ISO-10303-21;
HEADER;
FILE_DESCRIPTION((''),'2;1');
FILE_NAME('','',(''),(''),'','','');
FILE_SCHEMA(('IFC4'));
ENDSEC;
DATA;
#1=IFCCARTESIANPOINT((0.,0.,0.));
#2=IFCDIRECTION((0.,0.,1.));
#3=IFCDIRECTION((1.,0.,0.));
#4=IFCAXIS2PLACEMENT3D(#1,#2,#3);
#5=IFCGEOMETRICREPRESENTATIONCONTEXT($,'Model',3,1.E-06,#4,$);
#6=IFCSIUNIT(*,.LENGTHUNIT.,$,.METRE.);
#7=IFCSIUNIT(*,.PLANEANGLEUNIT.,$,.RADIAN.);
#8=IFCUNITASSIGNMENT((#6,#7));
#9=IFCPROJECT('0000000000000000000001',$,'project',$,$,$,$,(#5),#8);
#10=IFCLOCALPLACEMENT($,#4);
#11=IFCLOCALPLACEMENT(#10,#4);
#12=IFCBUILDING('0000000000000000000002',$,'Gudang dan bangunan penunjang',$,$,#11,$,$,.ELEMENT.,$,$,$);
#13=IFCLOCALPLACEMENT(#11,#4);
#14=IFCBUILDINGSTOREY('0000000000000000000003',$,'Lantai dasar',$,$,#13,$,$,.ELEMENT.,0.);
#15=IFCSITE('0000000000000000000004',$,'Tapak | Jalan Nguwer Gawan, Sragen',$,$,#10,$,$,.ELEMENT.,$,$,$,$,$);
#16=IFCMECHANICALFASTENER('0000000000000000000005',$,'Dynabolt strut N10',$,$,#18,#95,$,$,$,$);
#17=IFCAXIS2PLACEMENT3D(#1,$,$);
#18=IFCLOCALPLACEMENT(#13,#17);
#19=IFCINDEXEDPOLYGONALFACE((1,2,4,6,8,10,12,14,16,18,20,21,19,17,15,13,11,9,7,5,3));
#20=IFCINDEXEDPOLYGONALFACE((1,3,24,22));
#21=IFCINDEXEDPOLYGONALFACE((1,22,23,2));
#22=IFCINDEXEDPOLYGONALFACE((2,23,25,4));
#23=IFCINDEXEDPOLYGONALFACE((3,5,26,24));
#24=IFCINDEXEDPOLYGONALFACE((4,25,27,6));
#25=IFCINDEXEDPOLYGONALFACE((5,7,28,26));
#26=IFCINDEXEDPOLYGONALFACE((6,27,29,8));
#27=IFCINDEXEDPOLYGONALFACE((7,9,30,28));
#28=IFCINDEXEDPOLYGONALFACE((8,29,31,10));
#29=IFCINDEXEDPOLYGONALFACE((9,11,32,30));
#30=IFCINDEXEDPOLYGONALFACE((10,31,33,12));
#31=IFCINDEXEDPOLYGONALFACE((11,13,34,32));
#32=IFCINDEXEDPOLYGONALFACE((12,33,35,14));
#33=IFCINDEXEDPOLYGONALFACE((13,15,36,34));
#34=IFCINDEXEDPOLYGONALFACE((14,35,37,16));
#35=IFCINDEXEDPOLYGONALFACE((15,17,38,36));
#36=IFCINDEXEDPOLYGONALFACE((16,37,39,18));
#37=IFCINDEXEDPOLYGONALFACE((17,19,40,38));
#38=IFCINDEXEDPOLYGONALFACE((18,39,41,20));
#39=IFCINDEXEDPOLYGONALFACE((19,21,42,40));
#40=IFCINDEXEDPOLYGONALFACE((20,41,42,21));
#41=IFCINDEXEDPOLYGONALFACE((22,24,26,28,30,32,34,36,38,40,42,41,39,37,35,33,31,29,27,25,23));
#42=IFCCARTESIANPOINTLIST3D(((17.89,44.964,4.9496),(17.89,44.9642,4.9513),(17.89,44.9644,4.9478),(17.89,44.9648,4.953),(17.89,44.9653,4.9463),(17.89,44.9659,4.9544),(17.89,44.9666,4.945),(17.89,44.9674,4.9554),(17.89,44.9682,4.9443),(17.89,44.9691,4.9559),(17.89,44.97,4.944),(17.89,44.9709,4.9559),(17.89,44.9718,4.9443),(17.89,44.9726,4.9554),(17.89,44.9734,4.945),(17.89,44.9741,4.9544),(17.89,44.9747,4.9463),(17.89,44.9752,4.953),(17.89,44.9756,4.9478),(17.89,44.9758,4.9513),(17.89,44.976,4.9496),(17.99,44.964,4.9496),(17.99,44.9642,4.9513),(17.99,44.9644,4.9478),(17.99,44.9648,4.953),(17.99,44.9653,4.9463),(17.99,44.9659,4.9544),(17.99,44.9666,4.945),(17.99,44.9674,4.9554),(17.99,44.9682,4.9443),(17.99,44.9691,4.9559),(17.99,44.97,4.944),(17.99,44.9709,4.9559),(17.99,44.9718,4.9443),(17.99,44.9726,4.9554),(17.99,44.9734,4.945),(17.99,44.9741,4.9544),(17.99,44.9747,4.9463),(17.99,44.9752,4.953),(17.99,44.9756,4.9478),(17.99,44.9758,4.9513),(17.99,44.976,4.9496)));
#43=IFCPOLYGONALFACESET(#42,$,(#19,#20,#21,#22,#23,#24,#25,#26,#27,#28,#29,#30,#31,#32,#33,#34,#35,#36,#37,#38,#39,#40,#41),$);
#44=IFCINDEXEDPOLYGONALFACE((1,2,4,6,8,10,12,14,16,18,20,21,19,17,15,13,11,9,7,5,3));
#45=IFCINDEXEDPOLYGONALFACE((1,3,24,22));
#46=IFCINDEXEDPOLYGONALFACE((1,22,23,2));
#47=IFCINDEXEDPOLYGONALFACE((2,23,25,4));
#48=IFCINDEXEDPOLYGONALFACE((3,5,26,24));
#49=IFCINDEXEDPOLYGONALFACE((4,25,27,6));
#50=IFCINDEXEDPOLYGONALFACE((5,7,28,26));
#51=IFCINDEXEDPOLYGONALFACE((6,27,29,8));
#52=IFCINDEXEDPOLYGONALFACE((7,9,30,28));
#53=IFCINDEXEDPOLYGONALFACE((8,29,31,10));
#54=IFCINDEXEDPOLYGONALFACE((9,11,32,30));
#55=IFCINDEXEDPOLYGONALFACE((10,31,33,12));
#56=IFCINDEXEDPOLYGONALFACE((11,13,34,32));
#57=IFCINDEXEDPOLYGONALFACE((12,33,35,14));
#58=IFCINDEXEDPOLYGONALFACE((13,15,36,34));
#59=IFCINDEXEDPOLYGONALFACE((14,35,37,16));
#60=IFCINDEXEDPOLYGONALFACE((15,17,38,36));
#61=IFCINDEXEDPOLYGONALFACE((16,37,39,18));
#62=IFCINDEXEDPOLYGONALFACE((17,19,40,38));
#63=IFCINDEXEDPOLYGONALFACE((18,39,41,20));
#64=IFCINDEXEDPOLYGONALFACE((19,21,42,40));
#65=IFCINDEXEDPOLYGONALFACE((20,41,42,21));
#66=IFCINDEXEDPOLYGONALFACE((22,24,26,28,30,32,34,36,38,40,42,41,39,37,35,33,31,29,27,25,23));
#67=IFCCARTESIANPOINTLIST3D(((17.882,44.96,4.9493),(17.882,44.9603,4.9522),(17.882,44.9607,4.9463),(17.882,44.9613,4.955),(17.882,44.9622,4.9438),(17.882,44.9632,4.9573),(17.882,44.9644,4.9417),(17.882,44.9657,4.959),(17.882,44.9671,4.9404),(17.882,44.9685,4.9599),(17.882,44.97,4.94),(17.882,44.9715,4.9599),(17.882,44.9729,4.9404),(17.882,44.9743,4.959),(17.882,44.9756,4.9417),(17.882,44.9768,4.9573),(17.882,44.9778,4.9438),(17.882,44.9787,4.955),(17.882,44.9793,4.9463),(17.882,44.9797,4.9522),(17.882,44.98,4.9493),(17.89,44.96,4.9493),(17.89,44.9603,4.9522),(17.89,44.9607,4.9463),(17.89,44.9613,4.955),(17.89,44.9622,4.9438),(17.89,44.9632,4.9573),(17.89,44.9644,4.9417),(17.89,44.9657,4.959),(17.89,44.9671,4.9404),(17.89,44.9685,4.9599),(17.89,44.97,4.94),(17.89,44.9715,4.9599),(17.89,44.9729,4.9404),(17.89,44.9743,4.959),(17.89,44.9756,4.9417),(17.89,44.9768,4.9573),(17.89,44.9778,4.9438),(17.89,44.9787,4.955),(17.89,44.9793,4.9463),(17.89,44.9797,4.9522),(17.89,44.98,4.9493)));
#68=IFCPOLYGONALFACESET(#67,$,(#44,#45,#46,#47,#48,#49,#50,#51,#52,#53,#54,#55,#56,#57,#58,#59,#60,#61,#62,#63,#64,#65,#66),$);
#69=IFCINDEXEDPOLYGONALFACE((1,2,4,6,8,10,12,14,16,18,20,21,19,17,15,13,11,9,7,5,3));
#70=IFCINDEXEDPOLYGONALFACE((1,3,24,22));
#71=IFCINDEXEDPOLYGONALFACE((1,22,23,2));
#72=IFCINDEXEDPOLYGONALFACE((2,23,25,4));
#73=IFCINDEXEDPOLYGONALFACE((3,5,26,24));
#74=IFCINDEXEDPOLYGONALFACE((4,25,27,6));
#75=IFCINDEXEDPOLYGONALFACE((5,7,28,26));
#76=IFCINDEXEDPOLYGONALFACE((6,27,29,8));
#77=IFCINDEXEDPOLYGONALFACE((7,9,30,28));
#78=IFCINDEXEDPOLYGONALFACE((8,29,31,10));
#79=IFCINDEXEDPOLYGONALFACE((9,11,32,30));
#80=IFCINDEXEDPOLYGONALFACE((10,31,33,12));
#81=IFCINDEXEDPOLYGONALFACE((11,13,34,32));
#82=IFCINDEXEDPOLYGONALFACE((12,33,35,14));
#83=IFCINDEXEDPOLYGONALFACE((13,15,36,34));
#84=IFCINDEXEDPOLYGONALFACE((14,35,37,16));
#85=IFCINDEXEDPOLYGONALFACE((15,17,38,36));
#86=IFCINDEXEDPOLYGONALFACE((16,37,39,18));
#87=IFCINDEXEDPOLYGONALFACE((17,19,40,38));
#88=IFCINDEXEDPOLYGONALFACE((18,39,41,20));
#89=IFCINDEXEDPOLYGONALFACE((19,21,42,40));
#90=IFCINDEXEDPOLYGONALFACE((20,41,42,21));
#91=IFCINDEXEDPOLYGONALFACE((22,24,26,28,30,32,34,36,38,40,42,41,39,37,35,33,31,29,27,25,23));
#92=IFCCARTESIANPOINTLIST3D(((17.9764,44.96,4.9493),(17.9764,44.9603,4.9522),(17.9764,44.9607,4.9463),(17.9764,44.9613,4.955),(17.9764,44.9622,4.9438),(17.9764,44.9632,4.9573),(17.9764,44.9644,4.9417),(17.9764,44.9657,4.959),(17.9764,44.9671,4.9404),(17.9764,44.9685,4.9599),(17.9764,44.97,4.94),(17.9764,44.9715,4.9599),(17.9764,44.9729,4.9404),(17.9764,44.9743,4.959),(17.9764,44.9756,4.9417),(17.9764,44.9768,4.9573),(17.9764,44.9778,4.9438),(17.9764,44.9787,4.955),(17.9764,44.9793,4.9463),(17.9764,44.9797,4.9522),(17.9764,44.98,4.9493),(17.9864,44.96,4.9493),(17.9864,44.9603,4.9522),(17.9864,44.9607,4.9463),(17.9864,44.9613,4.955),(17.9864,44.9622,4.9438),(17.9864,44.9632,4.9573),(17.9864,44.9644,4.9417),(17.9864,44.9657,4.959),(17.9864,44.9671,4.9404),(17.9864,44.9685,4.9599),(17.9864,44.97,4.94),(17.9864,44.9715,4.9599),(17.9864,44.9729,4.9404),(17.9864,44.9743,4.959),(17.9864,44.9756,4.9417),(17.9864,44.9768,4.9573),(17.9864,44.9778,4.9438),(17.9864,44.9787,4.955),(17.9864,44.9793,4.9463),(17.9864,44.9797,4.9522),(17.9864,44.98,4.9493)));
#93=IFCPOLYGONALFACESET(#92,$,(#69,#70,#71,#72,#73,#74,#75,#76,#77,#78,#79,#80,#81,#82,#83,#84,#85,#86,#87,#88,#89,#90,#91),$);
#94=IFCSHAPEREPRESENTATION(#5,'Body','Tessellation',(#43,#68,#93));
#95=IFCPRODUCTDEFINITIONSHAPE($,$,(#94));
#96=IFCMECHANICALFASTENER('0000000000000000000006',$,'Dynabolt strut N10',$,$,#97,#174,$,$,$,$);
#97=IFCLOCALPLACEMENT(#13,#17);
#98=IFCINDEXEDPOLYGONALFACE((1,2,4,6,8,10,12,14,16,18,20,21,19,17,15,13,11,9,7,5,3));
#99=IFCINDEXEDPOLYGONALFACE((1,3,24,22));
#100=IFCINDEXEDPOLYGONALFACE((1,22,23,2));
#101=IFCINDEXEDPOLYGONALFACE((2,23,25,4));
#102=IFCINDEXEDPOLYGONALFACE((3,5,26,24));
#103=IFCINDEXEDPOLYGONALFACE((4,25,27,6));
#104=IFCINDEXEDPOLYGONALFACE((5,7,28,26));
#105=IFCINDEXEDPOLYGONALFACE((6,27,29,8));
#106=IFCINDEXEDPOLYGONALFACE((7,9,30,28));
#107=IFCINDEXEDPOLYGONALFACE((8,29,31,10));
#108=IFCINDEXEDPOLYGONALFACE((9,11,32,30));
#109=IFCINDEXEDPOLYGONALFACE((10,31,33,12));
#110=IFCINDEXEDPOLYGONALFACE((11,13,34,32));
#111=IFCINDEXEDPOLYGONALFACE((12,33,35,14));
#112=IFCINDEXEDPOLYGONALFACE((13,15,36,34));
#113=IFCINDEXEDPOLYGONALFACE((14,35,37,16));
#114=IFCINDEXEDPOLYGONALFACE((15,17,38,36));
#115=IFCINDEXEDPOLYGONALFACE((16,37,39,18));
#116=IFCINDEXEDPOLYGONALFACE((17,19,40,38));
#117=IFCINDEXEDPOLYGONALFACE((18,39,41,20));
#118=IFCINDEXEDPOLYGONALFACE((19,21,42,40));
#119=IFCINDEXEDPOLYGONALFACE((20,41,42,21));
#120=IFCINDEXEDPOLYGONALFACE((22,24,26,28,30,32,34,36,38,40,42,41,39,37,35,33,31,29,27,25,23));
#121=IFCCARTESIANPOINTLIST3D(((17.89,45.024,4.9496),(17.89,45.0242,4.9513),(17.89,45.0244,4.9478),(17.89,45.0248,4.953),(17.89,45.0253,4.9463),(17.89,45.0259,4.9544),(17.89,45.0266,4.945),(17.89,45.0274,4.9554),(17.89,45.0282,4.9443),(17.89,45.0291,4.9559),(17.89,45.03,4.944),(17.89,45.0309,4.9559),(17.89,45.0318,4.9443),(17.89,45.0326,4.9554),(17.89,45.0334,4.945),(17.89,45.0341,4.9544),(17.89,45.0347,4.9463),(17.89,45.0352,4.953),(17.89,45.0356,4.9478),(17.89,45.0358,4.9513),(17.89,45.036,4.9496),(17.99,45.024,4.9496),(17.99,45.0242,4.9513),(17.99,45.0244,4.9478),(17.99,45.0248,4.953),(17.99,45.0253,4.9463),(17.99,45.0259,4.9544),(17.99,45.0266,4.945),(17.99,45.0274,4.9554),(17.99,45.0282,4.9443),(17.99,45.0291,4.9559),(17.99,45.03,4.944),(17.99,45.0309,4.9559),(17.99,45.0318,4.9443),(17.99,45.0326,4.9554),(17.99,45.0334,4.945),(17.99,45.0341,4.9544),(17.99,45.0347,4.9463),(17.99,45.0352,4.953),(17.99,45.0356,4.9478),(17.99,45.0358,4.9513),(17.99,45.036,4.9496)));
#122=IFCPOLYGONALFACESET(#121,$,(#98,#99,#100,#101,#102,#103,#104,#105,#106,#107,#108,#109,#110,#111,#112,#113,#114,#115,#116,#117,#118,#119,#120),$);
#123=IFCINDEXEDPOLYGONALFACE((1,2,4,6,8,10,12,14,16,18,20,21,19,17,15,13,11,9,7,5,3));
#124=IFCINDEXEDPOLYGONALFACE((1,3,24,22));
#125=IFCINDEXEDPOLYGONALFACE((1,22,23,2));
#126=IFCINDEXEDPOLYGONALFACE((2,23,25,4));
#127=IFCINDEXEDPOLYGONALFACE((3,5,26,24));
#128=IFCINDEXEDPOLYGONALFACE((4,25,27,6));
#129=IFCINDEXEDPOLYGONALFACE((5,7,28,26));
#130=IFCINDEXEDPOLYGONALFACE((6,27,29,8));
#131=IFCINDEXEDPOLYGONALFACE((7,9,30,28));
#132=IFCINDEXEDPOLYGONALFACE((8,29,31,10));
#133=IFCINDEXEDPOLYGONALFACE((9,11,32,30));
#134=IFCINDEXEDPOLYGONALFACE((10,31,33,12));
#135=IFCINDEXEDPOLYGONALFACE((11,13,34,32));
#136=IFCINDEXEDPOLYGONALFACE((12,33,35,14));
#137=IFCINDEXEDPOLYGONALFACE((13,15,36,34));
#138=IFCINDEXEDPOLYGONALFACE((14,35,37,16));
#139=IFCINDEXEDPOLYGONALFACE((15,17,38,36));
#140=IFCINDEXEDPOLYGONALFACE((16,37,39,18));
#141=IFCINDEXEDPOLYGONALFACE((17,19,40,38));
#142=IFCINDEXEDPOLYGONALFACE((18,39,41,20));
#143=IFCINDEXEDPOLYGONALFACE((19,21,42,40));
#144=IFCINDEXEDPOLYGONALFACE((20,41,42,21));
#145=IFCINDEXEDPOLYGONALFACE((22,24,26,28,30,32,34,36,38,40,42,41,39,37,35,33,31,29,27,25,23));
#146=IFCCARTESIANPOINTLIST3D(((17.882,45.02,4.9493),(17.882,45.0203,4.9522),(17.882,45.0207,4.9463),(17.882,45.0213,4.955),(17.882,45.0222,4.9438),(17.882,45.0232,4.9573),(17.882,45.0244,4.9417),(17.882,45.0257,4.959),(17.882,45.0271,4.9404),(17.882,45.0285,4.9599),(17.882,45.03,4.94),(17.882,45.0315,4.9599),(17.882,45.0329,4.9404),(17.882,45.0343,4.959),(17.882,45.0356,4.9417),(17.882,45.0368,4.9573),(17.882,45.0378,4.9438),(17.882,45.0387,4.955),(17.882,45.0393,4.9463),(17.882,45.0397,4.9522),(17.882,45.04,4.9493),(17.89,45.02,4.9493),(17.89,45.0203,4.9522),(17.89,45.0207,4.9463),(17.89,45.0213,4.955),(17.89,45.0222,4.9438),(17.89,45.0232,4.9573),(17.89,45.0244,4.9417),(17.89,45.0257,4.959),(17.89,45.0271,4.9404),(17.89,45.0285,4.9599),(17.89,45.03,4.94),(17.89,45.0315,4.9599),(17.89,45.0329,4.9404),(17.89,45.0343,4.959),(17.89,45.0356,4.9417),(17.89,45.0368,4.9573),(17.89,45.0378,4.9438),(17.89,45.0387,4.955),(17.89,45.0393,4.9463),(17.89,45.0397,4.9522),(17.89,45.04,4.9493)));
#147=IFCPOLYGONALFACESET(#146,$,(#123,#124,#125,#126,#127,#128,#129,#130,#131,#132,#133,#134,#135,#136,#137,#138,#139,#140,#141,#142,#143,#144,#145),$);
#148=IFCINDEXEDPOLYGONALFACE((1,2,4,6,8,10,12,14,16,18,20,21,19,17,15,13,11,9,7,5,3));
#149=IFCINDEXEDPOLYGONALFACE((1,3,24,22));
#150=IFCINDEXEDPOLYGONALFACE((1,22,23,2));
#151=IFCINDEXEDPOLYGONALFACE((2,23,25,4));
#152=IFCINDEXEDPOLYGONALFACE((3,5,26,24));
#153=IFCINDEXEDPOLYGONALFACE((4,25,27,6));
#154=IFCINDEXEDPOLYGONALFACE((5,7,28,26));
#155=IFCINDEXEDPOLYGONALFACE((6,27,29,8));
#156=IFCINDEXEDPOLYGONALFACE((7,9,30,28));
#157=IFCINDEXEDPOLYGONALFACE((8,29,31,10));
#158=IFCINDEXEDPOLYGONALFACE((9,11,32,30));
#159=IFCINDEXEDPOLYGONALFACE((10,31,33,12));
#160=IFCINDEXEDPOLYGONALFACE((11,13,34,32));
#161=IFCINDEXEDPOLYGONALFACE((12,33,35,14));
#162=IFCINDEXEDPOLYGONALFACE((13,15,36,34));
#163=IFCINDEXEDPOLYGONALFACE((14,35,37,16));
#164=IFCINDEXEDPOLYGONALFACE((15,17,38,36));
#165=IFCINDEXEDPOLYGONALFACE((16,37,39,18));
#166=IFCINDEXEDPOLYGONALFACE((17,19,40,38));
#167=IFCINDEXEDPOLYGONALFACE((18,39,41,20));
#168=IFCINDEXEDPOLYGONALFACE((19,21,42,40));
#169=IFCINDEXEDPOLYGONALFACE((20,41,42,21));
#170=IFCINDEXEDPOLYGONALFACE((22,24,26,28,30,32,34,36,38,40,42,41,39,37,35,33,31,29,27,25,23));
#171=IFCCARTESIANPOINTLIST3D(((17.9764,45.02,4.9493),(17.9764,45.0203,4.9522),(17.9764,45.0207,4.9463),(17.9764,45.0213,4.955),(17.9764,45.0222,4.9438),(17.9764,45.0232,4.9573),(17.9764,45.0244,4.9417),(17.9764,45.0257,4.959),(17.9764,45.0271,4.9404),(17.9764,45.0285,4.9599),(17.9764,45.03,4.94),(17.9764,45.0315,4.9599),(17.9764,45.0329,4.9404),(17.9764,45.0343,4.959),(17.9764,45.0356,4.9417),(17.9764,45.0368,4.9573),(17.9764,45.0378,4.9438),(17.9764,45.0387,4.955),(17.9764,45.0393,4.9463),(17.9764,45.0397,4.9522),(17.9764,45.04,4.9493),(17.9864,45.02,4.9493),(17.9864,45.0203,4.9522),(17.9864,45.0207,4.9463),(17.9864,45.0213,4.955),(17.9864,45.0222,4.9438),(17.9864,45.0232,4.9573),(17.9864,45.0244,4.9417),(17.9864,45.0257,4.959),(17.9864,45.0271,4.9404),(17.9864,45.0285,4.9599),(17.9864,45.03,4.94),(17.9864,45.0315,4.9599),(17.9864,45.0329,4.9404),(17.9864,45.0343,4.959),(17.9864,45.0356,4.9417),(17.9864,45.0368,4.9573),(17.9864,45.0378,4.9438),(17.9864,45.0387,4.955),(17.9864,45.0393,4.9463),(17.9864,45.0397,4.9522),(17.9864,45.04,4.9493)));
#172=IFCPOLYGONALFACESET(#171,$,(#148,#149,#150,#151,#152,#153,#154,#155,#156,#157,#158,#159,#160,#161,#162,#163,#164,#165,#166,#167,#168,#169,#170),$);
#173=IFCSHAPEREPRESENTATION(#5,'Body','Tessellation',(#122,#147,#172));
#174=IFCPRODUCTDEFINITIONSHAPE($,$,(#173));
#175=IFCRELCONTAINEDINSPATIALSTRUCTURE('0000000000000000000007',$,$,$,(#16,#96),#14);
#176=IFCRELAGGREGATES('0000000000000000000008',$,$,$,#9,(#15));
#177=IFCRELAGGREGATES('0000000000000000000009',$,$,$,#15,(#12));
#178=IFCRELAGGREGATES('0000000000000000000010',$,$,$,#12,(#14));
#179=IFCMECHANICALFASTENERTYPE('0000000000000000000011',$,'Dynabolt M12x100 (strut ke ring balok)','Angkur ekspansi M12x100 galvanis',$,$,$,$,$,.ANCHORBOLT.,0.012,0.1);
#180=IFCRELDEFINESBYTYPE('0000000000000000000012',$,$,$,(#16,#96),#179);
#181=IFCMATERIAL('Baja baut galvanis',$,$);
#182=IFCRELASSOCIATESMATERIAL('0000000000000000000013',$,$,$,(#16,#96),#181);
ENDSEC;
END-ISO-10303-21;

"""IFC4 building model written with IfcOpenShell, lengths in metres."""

from ifc_helpers import new_model, si_unit, frame, origin_with_axes, place, context, project, spatial, circle, extrude, source, transform, mapped, material, type_object, type_shapes, element, save


model = new_model("IFC4")

# Units and contexts
model_context = context("Model", 3, precision=1e-06, world=origin_with_axes())
ifc_project = project(units=[si_unit("LENGTHUNIT", "METRE"), si_unit("PLANEANGLEUNIT", "RADIAN")], contexts=[model_context])

# Site, building, storey
site_placement = place(None, origin_with_axes())
site = spatial("IfcSite", under=ifc_project, at=site_placement, Name="Tapak | Jalan Nguwer Gawan, Sragen", CompositionType="ELEMENT")
building_placement = place(site_placement, origin_with_axes())
building = spatial("IfcBuilding", under=site, at=building_placement, Name="Gudang dan bangunan penunjang", CompositionType="ELEMENT")
storey_placement = place(building_placement, origin_with_axes())
storey = spatial("IfcBuildingStorey", under=building, at=storey_placement, Name="Lantai dasar", CompositionType="ELEMENT", Elevation=0.0)

# Mechanical fasteners
ifc_material = material(Name="Baja baut galvanis")
mechanical_fastener_type = type_object("IfcMechanicalFastenerType", Name="Dynabolt M12x100 (strut ke ring balok)", Description="Angkur ekspansi M12x100 galvanis", NominalDiameter=0.012, NominalLength=0.1, PredefinedType="ANCHORBOLT")
shared_shape = source(origin_with_axes(), model_context, "Body", "SweptSolid", [
    extrude(circle(Radius=0.006), origin_with_axes(), (0.0, 0.0, 1.0), 0.1),
    extrude(circle(Radius=0.01), frame((0.0, 0.0, -0.008), z_axis=(0.0, 0.0, 1.0), x_axis=(1.0, 0.0, 0.0)), (0.0, 0.0, 1.0), 0.008),
    extrude(circle(Radius=0.01), frame((0.0, 0.0, 0.0864), z_axis=(0.0, 0.0, 1.0), x_axis=(1.0, 0.0, 0.0)), (0.0, 0.0, 1.0), 0.01),
])
type_shapes(mechanical_fastener_type, [shared_shape])
placement = place(None, origin_with_axes())
element("IfcMechanicalFastener", 1, at=placement, inside=storey, type_object=mechanical_fastener_type, material=ifc_material, Name="Dynabolt strut N10", context=model_context, shape_type="MappedRepresentation", body=[
    mapped(shared_shape, transform((17.89, 44.97, 4.95), x_axis=(0.0, 0.0, -1.0), y_axis=(0.0, 1.0, 0.0), z_axis=(1.0, 0.0, 0.0), scale=1.0)),
])
element("IfcMechanicalFastener", 2, at=placement, inside=storey, type_object=mechanical_fastener_type, material=ifc_material, Name="Dynabolt strut N10", context=model_context, shape_type="MappedRepresentation", body=[
    mapped(shared_shape, transform((17.89, 45.03, 4.95), x_axis=(0.0, 0.0, -1.0), y_axis=(0.0, 1.0, 0.0), z_axis=(1.0, 0.0, 0.0), scale=1.0)),
])

save(model, "model.ifc")
